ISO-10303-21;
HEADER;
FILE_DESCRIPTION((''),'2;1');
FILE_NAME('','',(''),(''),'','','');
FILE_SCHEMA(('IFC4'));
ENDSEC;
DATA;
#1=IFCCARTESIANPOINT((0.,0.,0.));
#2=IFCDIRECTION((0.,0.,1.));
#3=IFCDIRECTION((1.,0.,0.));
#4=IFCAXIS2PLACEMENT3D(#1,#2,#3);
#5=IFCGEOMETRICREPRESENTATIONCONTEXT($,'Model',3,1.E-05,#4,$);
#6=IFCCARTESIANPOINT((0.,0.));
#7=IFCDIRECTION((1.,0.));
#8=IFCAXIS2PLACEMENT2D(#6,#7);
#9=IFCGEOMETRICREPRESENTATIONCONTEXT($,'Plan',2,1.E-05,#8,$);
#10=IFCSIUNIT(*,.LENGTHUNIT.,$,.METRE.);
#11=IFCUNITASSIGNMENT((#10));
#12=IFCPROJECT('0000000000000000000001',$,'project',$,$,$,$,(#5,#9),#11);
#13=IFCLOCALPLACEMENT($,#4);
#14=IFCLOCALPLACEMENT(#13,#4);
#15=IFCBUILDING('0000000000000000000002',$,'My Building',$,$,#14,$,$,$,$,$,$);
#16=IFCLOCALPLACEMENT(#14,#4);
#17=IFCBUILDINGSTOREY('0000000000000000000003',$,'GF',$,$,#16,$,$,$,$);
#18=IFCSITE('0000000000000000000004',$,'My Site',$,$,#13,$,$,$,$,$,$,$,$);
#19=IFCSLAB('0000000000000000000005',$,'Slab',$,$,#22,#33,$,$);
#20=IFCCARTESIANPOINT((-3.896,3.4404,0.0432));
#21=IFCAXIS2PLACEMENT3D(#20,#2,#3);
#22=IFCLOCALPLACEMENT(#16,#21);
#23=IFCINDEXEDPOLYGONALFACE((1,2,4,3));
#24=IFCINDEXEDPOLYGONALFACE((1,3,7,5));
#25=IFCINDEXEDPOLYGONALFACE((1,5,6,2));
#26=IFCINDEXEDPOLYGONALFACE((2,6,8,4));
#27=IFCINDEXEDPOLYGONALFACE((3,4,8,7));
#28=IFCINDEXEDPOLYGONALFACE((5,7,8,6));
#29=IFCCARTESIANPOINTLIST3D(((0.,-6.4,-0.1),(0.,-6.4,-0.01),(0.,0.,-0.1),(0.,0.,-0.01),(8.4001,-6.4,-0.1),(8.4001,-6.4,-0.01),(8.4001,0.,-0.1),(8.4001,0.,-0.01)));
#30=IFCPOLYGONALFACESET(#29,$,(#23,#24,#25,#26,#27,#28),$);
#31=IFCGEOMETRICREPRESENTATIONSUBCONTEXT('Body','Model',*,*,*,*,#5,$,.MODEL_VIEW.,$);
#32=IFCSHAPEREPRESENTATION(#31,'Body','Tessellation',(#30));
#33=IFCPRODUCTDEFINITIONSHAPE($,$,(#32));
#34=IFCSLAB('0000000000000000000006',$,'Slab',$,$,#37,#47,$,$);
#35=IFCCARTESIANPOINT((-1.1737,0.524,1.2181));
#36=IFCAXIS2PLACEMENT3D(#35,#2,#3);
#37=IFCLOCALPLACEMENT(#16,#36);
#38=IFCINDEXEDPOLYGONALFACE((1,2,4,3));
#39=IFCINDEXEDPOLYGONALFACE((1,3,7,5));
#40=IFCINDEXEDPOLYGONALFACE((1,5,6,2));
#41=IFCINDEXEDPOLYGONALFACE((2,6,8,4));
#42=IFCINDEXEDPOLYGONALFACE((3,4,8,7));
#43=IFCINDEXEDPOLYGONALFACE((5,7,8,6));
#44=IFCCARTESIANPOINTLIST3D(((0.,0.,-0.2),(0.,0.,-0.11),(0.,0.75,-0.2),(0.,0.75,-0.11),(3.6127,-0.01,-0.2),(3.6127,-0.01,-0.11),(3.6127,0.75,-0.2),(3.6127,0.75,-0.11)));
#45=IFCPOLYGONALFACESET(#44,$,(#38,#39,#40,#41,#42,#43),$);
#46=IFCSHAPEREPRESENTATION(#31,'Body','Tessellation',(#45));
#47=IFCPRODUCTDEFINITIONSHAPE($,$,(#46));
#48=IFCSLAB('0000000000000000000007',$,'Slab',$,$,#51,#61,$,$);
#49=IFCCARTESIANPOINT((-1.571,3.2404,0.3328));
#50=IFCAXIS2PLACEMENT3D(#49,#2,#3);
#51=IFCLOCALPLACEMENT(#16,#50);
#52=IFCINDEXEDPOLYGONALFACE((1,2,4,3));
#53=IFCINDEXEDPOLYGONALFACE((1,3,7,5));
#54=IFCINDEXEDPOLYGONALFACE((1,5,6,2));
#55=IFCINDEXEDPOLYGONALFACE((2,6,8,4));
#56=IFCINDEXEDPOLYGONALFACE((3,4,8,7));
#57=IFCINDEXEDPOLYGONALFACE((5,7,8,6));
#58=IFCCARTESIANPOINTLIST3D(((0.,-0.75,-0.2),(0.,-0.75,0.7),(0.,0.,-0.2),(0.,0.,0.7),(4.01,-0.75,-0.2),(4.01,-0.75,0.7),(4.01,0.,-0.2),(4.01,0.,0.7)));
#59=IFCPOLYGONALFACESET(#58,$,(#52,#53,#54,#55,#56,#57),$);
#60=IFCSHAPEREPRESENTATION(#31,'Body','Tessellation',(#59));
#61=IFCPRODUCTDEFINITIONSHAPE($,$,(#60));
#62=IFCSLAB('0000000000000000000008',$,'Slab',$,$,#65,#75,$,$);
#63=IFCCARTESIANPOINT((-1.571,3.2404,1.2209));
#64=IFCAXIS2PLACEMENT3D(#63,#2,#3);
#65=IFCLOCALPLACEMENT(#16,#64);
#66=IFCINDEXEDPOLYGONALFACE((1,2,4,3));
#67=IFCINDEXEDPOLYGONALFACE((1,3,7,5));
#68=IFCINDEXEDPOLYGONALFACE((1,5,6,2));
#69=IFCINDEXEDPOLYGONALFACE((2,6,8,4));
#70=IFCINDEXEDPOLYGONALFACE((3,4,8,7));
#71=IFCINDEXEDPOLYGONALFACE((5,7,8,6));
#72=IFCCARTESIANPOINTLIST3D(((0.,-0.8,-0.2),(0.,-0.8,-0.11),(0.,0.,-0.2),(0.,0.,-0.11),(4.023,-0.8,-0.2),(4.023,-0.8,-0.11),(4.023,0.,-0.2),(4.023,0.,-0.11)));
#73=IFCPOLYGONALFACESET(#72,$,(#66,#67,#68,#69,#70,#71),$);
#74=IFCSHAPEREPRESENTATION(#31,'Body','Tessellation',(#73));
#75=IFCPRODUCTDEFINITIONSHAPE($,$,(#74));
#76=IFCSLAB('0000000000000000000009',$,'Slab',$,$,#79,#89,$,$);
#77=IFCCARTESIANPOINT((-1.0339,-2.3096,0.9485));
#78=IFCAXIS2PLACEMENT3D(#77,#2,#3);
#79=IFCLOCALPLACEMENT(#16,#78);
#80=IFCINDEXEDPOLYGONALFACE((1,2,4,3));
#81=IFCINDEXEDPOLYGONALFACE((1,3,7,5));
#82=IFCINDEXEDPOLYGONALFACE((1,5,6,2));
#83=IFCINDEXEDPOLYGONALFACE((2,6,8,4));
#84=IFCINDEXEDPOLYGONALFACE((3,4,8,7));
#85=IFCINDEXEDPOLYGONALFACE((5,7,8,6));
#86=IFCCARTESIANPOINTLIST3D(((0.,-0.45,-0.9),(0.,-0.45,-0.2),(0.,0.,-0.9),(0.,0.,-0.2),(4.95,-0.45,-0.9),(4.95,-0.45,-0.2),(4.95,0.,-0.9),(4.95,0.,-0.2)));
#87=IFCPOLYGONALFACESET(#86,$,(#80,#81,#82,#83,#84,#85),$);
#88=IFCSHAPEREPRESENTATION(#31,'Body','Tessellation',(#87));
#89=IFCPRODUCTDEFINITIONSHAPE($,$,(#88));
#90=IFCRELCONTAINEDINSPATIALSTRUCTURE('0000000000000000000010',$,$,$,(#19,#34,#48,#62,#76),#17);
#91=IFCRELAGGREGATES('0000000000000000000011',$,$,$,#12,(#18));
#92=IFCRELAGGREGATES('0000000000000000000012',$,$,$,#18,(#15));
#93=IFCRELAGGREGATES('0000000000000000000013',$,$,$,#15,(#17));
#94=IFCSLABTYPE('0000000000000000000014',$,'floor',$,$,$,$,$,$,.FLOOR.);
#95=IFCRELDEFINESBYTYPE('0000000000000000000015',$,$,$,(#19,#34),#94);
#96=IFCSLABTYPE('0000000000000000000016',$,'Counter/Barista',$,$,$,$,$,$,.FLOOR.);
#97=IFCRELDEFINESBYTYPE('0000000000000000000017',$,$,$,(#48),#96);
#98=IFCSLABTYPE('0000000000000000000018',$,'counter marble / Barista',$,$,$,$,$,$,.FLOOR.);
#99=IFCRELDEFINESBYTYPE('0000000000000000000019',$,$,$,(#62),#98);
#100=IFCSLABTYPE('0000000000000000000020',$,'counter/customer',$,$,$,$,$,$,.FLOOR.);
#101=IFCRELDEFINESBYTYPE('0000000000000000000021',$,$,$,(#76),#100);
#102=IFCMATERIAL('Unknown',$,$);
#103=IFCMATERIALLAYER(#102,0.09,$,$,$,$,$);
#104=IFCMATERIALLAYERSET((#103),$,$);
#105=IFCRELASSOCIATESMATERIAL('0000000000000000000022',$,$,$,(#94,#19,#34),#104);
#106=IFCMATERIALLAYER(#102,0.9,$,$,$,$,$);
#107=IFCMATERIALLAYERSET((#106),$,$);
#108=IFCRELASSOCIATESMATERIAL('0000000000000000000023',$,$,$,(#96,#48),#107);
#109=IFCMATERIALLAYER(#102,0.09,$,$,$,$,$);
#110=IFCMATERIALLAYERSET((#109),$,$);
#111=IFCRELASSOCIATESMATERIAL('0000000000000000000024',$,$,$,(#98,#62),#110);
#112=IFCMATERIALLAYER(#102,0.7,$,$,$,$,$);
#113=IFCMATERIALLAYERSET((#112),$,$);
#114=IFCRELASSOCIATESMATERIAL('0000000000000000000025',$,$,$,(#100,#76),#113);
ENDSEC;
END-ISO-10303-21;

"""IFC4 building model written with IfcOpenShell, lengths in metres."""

from ifc_helpers import new_model, si_unit, frame, origin_with_axes, origin_2d_with_axis, place, context, subcontext, project, spatial, indexed_curve, outline, extrude, material, layer, layer_set, layer_usage, type_object, element, save


model = new_model("IFC4")

# Units and contexts
model_context = context("Model", 3, precision=1e-05, world=origin_with_axes())
plan_context = context("Plan", 2, precision=1e-05, world=origin_2d_with_axis())
body_context_1 = subcontext(model_context, "Body", "Model", "MODEL_VIEW")
ifc_project = project(units=[si_unit("LENGTHUNIT", "METRE")], contexts=[model_context, plan_context])

# Site, building, storey
site_placement = place(None, origin_with_axes())
site = spatial("IfcSite", under=ifc_project, at=site_placement, Name="My Site")
building_placement = place(site_placement, origin_with_axes())
building = spatial("IfcBuilding", under=site, at=building_placement, Name="My Building")
storey_placement = place(building_placement, origin_with_axes())
storey = spatial("IfcBuildingStorey", under=building, at=storey_placement, Name="GF")

# Shared definitions
ifc_material = material(Name="Unknown")

# Slabs
ifc_layer_1 = layer(ifc_material, 0.09)
ifc_layer_set_1 = layer_set([ifc_layer_1])
ifc_layer_usage_1 = layer_usage(ifc_layer_set_1, "AXIS3", "POSITIVE", -0.1)
slab_type_1 = type_object("IfcSlabType", Name="floor", PredefinedType="FLOOR", material=ifc_layer_set_1)
slab_1_placement = place(storey_placement, frame((-3.896, 3.4404, 0.0432), z_axis=(0.0, 0.0, 1.0), x_axis=(1.0, 0.0, 0.0)))
element("IfcSlab", 1, at=slab_1_placement, inside=storey, type_object=slab_type_1, material=ifc_layer_usage_1, Name="Slab", context=body_context_1, shape_type="SweptSolid", body=[
    extrude(outline(indexed_curve([(0.0, 0.0), (0.0, -6.4), (8.4001, -6.4), (8.4001, 0.0), (0.0, 0.0)])), frame((0.0, 0.0, -0.1), z_axis=(0.0, 0.0, 1.0), x_axis=(1.0, 0.0, 0.0)), (0.0, 0.0, 1.0), 0.09),
])
ifc_layer_usage_2 = layer_usage(ifc_layer_set_1, "AXIS3", "POSITIVE", -0.2)
slab_2_placement = place(storey_placement, frame((-1.1737, 0.524, 1.2181), z_axis=(0.0, 0.0, 1.0), x_axis=(1.0, 0.0, 0.0)))
element("IfcSlab", 2, at=slab_2_placement, inside=storey, type_object=slab_type_1, material=ifc_layer_usage_2, Name="Slab", context=body_context_1, shape_type="SweptSolid", body=[
    extrude(outline(indexed_curve([(0.0, 0.0), (0.0, 0.75), (3.6127, 0.75), (3.6127, -0.01), (0.0, 0.0)])), frame((0.0, 0.0, -0.2), z_axis=(0.0, 0.0, 1.0), x_axis=(1.0, 0.0, 0.0)), (0.0, 0.0, 1.0), 0.09),
])
ifc_layer_2 = layer(ifc_material, 0.9)
ifc_layer_set_2 = layer_set([ifc_layer_2])
ifc_layer_usage_3 = layer_usage(ifc_layer_set_2, "AXIS3", "POSITIVE", -0.2)
slab_type_2 = type_object("IfcSlabType", Name="Counter/Barista", PredefinedType="FLOOR", material=ifc_layer_set_2)
slab_3_placement = place(storey_placement, frame((-1.571, 3.2404, 0.3328), z_axis=(0.0, 0.0, 1.0), x_axis=(1.0, 0.0, 0.0)))
element("IfcSlab", 3, at=slab_3_placement, inside=storey, type_object=slab_type_2, material=ifc_layer_usage_3, Name="Slab", context=body_context_1, shape_type="SweptSolid", body=[
    extrude(outline(indexed_curve([(0.0, 0.0), (0.0, -0.75), (4.01, -0.75), (4.01, 0.0), (0.0, 0.0)])), frame((0.0, 0.0, -0.2), z_axis=(0.0, 0.0, 1.0), x_axis=(1.0, 0.0, 0.0)), (0.0, 0.0, 1.0), 0.9),
])
ifc_layer_3 = layer(ifc_material, 0.09)
ifc_layer_set_3 = layer_set([ifc_layer_3])
ifc_layer_usage_4 = layer_usage(ifc_layer_set_3, "AXIS3", "POSITIVE", -0.2)
slab_type_3 = type_object("IfcSlabType", Name="counter marble / Barista", PredefinedType="FLOOR", material=ifc_layer_set_3)
slab_4_placement = place(storey_placement, frame((-1.571, 3.2404, 1.2209), z_axis=(0.0, 0.0, 1.0), x_axis=(1.0, 0.0, 0.0)))
element("IfcSlab", 4, at=slab_4_placement, inside=storey, type_object=slab_type_3, material=ifc_layer_usage_4, Name="Slab", context=body_context_1, shape_type="SweptSolid", body=[
    extrude(outline(indexed_curve([(0.0, 0.0), (0.0, -0.8), (4.023, -0.8), (4.023, 0.0), (0.0, 0.0)])), frame((0.0, 0.0, -0.2), z_axis=(0.0, 0.0, 1.0), x_axis=(1.0, 0.0, 0.0)), (0.0, 0.0, 1.0), 0.09),
])
ifc_layer_4 = layer(ifc_material, 0.7)
ifc_layer_set_4 = layer_set([ifc_layer_4])
ifc_layer_usage_5 = layer_usage(ifc_layer_set_4, "AXIS3", "POSITIVE", -0.9)
slab_type_4 = type_object("IfcSlabType", Name="counter/customer", PredefinedType="FLOOR", material=ifc_layer_set_4)
slab_5_placement = place(storey_placement, frame((-1.0339, -2.3096, 0.9485), z_axis=(0.0, 0.0, 1.0), x_axis=(1.0, 0.0, 0.0)))
element("IfcSlab", 5, at=slab_5_placement, inside=storey, type_object=slab_type_4, material=ifc_layer_usage_5, Name="Slab", context=body_context_1, shape_type="SweptSolid", body=[
    extrude(outline(indexed_curve([(0.0, 0.0), (0.0, -0.45), (4.95, -0.45), (4.95, 0.0), (0.0, 0.0)])), frame((0.0, 0.0, -0.9), z_axis=(0.0, 0.0, 1.0), x_axis=(1.0, 0.0, 0.0)), (0.0, 0.0, 1.0), 0.7),
])

save(model, "model.ifc")
